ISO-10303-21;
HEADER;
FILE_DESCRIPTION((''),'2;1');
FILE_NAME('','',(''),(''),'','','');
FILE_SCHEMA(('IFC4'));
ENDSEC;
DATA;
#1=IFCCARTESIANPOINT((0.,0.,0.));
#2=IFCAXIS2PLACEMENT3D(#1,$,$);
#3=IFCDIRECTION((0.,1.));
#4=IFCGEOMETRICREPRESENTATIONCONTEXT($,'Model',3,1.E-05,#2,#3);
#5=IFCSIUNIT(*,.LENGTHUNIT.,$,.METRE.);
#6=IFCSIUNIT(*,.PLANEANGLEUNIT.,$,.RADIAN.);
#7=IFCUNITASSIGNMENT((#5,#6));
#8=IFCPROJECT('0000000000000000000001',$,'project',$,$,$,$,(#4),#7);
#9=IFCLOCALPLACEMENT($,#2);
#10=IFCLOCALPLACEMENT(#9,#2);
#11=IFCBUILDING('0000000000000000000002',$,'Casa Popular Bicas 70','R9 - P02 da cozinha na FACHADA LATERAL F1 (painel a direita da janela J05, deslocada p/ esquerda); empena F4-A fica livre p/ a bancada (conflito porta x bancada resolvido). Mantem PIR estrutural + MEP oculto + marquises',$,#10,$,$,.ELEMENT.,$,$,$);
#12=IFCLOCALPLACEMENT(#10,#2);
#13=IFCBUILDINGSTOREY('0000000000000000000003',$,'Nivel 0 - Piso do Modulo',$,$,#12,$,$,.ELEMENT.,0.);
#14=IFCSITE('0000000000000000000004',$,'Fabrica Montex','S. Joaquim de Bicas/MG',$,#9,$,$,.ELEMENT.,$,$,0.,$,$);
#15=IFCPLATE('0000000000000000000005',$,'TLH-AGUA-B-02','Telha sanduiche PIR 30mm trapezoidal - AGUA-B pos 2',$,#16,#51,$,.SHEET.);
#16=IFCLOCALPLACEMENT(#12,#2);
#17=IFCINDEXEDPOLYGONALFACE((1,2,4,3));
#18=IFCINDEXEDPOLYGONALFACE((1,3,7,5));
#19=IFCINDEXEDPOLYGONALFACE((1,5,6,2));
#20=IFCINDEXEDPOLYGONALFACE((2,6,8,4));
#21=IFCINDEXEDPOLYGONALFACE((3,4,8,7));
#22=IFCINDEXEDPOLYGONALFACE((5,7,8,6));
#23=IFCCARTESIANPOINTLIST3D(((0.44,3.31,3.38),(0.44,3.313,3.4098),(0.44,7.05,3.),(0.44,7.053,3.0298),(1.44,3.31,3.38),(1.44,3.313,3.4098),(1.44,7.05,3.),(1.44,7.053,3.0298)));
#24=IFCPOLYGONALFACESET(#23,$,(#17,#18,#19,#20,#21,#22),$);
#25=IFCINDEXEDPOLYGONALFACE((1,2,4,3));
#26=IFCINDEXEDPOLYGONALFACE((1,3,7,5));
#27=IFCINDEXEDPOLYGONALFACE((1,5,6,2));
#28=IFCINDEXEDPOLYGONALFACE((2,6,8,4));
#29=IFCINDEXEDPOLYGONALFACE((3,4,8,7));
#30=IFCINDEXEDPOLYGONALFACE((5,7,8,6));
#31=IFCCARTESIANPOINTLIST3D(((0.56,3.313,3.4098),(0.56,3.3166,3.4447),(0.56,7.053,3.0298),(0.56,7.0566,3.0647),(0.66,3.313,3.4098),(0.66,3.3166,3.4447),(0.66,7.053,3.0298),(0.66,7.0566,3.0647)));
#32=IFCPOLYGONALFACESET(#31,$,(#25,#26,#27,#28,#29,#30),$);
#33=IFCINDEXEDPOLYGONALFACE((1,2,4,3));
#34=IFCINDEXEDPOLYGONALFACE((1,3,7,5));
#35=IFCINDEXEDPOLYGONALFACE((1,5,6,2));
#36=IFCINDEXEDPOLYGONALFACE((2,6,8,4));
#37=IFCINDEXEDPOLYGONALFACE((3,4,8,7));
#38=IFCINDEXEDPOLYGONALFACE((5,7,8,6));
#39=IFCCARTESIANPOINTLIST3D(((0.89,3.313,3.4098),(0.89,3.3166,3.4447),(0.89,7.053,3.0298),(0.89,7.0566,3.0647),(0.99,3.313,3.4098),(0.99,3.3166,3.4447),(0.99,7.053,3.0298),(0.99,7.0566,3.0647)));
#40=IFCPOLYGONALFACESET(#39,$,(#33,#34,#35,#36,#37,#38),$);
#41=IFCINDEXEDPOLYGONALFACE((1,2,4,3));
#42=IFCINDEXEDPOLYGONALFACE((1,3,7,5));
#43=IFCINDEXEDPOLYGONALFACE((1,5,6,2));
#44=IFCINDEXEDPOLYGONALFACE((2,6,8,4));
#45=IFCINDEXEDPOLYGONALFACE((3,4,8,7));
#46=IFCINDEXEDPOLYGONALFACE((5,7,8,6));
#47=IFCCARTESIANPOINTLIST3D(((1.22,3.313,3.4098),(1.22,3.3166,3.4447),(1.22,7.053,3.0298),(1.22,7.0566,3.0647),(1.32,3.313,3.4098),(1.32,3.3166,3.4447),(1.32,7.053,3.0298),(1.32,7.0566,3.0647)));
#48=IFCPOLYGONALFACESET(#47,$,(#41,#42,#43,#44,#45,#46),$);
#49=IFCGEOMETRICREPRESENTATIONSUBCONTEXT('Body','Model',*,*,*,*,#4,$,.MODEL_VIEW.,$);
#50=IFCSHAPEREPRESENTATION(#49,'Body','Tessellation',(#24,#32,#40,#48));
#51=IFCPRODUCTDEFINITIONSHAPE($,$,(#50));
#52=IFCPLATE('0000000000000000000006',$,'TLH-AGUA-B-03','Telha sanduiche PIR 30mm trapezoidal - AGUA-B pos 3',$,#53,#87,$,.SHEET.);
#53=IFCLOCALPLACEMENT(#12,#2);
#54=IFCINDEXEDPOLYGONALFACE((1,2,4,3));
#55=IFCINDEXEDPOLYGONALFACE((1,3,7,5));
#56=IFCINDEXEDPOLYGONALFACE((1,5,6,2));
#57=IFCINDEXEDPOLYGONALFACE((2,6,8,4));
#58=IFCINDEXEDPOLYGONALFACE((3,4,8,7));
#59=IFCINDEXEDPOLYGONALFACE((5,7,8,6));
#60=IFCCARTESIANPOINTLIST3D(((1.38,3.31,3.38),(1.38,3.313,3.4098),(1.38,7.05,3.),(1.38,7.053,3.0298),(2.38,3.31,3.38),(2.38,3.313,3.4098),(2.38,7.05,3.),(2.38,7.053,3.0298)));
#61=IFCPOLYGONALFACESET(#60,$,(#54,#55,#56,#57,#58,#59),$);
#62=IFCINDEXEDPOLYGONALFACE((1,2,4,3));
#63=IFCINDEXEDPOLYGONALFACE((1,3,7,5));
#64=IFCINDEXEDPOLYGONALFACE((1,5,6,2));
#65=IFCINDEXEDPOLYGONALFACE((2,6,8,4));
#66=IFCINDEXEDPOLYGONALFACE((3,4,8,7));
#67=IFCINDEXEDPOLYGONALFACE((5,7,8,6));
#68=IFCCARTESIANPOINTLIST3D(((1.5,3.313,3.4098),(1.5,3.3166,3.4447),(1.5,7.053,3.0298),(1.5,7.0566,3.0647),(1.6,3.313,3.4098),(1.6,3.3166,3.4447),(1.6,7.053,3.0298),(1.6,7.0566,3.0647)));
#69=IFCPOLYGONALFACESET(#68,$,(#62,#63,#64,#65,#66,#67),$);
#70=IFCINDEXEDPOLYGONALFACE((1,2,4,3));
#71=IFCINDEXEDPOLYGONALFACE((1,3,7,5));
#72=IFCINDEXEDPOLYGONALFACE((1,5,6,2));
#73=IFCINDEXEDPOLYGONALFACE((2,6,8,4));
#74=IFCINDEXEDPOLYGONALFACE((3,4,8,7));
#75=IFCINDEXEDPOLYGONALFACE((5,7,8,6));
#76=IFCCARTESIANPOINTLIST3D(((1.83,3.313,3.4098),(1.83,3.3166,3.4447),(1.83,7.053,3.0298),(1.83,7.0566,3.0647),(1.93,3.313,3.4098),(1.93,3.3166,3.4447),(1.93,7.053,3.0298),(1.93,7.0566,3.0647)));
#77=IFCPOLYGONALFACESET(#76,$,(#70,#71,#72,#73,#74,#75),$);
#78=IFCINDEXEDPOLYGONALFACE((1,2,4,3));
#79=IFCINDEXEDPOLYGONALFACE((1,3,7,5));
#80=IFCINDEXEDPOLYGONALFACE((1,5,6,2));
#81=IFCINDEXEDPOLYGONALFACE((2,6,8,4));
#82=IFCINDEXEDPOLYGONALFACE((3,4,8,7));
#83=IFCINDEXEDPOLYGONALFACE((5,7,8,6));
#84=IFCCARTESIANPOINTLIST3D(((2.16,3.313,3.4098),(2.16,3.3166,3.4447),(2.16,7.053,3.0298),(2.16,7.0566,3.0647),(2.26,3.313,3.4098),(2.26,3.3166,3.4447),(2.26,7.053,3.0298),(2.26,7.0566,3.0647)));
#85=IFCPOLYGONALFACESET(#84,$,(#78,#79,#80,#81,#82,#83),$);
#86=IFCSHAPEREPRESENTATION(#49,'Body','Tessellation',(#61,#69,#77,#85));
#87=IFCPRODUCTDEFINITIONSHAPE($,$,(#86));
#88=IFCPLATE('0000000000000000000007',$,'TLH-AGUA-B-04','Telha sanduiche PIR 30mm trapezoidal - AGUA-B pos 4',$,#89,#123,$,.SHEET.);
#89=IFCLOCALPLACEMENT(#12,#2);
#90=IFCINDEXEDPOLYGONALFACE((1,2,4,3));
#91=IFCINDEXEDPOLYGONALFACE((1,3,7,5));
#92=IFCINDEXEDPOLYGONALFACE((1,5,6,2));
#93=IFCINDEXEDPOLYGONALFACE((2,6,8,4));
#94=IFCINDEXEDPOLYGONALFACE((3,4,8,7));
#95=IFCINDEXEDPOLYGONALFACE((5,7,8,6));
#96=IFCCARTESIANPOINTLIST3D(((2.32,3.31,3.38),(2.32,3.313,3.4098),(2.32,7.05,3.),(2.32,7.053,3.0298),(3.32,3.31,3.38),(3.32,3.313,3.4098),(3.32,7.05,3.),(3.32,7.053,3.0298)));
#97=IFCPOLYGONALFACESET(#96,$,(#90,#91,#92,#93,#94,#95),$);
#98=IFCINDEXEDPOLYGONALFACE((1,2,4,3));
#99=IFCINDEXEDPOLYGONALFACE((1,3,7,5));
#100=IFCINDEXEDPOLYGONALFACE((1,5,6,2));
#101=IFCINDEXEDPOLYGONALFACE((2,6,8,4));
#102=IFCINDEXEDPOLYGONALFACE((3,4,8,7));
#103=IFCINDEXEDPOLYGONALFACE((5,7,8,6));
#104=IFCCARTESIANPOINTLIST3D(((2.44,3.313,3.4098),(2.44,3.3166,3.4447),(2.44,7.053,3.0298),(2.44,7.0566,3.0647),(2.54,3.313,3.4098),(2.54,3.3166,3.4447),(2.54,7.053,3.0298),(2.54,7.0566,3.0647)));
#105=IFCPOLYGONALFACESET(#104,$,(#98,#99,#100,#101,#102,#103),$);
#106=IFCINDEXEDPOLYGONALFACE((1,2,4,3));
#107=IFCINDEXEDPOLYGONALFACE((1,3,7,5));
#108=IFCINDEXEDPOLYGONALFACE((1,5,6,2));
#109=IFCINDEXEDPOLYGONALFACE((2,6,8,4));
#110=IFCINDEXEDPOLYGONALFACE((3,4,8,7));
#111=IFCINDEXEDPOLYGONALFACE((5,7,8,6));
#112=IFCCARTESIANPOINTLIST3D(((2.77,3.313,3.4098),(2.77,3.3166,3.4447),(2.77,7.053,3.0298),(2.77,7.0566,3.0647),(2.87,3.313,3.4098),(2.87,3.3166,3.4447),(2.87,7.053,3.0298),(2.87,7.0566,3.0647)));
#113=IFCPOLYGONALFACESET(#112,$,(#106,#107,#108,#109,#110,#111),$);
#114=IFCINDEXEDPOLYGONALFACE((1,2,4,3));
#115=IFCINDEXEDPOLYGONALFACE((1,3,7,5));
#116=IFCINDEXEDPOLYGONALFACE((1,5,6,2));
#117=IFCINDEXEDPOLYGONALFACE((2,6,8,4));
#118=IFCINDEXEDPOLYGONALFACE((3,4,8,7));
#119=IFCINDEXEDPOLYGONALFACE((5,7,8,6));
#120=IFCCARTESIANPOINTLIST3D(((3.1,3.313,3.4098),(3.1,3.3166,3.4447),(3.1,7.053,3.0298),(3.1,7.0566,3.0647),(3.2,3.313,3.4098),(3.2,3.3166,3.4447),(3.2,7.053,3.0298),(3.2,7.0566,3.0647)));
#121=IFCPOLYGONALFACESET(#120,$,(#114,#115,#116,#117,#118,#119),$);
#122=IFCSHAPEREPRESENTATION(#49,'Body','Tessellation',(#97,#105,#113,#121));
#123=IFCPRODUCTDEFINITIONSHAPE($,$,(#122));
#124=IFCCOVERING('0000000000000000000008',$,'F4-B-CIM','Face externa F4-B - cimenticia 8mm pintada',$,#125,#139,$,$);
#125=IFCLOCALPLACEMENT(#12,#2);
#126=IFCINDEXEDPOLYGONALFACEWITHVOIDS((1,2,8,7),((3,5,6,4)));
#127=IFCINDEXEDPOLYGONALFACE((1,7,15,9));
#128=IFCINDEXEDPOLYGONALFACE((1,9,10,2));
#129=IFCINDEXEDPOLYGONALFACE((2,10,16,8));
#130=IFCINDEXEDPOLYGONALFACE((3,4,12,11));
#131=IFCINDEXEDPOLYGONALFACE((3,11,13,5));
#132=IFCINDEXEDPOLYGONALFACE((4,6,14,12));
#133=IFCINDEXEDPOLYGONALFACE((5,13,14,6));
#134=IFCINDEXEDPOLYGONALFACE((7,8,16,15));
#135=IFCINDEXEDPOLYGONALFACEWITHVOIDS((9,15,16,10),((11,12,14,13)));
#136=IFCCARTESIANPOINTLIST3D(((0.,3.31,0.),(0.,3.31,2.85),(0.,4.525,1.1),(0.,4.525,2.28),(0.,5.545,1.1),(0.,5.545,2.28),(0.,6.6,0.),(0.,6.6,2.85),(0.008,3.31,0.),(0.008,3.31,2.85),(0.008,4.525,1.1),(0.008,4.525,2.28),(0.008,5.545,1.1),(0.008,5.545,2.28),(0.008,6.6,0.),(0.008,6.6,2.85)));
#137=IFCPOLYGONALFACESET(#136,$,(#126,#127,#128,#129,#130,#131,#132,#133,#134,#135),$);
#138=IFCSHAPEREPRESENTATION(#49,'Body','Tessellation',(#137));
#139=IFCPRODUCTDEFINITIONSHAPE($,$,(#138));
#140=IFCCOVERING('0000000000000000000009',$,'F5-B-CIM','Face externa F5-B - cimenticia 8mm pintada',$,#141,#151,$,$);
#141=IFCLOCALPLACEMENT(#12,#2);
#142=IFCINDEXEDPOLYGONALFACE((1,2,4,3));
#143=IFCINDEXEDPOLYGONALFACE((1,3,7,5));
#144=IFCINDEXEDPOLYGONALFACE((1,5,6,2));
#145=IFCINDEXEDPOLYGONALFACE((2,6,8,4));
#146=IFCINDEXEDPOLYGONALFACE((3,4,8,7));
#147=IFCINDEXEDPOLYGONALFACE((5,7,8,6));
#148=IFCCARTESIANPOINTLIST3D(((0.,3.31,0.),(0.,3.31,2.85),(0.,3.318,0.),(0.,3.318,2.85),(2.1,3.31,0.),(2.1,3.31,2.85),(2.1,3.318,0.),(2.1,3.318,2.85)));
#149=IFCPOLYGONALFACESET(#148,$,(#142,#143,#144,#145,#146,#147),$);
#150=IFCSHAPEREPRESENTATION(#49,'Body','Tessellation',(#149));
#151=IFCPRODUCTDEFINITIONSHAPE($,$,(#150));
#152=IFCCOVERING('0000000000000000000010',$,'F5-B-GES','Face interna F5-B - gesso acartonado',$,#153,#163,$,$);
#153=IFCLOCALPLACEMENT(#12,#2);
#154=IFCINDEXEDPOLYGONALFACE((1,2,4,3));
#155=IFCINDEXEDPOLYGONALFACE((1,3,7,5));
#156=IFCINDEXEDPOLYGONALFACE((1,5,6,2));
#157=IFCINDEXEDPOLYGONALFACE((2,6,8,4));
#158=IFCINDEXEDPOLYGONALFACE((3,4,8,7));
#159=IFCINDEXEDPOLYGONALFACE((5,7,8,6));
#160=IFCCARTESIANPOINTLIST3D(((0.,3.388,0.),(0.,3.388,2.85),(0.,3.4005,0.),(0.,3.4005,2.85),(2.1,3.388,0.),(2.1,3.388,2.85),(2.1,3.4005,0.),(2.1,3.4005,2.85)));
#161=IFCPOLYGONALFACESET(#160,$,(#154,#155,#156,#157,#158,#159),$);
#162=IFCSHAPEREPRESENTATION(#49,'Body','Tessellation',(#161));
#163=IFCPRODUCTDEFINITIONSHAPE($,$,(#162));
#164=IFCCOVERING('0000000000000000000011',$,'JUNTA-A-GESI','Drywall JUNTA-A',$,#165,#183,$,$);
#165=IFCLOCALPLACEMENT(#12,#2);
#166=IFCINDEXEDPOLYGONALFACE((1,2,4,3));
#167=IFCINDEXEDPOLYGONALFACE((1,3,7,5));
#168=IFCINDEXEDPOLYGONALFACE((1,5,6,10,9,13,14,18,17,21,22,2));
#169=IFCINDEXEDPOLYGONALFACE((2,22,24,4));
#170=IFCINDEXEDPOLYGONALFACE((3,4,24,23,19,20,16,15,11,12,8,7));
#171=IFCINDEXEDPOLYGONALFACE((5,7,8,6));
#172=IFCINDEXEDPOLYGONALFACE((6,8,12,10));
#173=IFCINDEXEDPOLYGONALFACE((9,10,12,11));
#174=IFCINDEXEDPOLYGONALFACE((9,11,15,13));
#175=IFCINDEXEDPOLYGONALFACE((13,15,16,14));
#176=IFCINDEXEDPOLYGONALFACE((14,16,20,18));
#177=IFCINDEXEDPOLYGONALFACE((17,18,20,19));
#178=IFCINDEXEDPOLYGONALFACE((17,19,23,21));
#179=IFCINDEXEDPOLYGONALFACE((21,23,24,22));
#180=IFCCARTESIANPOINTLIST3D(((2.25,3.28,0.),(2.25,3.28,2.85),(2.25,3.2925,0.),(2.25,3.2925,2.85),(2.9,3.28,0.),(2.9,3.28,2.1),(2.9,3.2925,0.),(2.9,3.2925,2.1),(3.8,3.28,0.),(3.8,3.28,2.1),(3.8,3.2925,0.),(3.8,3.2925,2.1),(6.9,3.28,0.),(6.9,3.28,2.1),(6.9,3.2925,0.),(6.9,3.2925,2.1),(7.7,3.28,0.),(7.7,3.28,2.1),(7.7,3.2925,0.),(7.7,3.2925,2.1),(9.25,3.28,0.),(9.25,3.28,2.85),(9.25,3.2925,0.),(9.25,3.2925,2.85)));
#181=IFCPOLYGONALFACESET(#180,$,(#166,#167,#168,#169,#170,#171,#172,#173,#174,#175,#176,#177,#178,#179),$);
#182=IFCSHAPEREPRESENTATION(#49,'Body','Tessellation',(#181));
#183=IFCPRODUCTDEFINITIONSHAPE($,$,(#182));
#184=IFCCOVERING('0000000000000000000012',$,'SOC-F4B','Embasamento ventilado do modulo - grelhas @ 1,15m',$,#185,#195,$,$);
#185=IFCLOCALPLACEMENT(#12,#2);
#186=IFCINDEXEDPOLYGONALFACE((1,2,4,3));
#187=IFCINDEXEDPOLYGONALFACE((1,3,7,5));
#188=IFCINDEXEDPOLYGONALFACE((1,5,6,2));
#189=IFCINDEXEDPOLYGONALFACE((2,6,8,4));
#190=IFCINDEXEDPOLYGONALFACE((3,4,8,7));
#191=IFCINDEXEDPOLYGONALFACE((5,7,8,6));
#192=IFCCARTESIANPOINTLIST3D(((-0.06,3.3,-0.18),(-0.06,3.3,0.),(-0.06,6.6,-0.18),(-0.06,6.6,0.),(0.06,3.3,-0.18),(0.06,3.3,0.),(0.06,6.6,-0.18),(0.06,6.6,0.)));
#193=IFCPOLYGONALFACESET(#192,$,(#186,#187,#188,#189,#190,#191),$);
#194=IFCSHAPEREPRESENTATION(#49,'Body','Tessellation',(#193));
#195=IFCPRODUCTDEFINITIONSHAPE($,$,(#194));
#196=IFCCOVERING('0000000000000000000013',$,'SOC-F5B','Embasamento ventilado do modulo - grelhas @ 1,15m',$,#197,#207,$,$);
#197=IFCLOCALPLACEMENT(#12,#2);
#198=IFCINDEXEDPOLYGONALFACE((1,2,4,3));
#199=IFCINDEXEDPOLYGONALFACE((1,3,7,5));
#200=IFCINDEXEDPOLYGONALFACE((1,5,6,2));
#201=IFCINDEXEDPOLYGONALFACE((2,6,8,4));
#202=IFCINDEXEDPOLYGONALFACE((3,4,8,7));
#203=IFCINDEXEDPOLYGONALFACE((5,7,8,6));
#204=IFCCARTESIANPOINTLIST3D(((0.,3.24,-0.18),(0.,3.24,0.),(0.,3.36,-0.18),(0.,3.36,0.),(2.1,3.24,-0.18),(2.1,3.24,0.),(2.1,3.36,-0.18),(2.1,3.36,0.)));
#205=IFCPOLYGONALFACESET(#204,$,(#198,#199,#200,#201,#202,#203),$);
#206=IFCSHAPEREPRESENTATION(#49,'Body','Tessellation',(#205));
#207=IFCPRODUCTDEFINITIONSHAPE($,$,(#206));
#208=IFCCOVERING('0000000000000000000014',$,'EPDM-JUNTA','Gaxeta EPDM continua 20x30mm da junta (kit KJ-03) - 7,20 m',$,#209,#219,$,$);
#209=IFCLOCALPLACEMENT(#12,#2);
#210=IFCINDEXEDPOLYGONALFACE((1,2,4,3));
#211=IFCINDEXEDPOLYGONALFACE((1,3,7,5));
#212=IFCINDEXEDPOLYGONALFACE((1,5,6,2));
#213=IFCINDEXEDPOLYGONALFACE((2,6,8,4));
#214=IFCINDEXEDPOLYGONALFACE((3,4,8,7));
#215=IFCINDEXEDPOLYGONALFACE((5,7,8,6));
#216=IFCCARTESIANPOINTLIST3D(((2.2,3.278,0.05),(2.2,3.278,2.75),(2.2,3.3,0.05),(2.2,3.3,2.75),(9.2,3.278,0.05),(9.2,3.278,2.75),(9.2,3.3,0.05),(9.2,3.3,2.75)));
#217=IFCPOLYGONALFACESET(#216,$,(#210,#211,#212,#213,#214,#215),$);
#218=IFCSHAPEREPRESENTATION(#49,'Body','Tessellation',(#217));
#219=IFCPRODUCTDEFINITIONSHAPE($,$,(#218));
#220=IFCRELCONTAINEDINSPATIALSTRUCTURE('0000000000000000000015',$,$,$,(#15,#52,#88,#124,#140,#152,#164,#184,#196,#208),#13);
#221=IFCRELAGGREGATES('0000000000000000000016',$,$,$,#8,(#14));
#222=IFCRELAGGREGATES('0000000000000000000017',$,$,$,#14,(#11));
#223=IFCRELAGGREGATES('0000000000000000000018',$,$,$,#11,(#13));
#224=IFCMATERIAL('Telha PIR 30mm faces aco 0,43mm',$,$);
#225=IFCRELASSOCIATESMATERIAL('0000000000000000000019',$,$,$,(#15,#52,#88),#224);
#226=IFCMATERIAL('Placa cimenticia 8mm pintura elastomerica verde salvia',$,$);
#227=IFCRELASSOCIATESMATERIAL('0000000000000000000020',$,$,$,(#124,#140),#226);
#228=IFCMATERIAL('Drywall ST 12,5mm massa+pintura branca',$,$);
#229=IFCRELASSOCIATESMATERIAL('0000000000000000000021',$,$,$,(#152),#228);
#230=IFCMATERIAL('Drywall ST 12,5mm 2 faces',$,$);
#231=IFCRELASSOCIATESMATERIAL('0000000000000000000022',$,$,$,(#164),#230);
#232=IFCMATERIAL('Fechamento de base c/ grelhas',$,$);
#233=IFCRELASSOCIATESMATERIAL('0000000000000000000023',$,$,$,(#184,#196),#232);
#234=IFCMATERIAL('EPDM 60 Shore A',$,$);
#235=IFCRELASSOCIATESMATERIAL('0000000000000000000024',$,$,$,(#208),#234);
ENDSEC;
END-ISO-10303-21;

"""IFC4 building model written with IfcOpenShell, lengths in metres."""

from ifc_helpers import new_model, si_unit, direction, frame, frame_2d, origin, origin_2d, place, context, subcontext, project, spatial, rectangle, extrude, material, element, save


model = new_model("IFC4")

# Units and contexts
model_context = context("Model", 3, precision=1e-05, world=origin(), true_north=direction((0.0, 1.0)))
body_context = subcontext(model_context, "Body", "Model", "MODEL_VIEW")
ifc_project = project(units=[si_unit("LENGTHUNIT", "METRE"), si_unit("PLANEANGLEUNIT", "RADIAN")], contexts=[model_context])

# Site, building, storey
site_placement = place(None, origin())
site = spatial("IfcSite", under=ifc_project, at=site_placement, Name="Fabrica Montex", Description="S. Joaquim de Bicas/MG", CompositionType="ELEMENT", RefElevation=0.0)
building_placement = place(site_placement, origin())
building = spatial("IfcBuilding", under=site, at=building_placement, Name="Casa Popular Bicas 70", Description="R9 - P02 da cozinha na FACHADA LATERAL F1 (painel a direita da janela J05, deslocada p/ esquerda); empena F4-A fica livre p/ a bancada (conflito porta x bancada resolvido). Mantem PIR estrutural + MEP oculto + marquises", CompositionType="ELEMENT")
storey_placement = place(building_placement, origin())
storey = spatial("IfcBuildingStorey", under=building, at=storey_placement, Name="Nivel 0 - Piso do Modulo", CompositionType="ELEMENT", Elevation=0.0)

# Plates
ifc_material_1 = material(Name="Telha PIR 30mm faces aco 0,43mm")
for number, where, z_axis, x_axis, name, description in (
    (1, (0.44, 3.31, 3.38), (0.0, 0.101084, 0.994878), (1.0, 0.0, 0.0), "TLH-AGUA-B-02", "Telha sanduiche PIR 30mm trapezoidal - AGUA-B pos 2"),
    (2, (1.38, 3.31, 3.38), (0.0, 0.101084, 0.994878), (1.0, 0.0, 0.0), "TLH-AGUA-B-03", "Telha sanduiche PIR 30mm trapezoidal - AGUA-B pos 3"),
    (3, (2.32, 3.31, 3.38), (0.0, 0.101084, 0.994878), (1.0, 0.0, 0.0), "TLH-AGUA-B-04", "Telha sanduiche PIR 30mm trapezoidal - AGUA-B pos 4"),
):
    element("IfcPlate", number, at=place(storey_placement, frame(where, z_axis=z_axis, x_axis=x_axis)), inside=storey, material=ifc_material_1, Name=name, Description=description, PredefinedType="SHEET", context=body_context, shape_type="SweptSolid", body=[
        extrude(rectangle(XDim=1.0, YDim=3.7593, at=frame_2d((0.5, 1.8796))), origin(), (0.0, 0.0, 1.0), 0.03),
        extrude(rectangle(XDim=0.1, YDim=3.7593, at=frame_2d((0.17, 1.8796))), frame((0.0, 0.0, 0.03)), (0.0, 0.0, 1.0), 0.035),
        extrude(rectangle(XDim=0.1, YDim=3.7593, at=frame_2d((0.5, 1.8796))), frame((0.0, 0.0, 0.03)), (0.0, 0.0, 1.0), 0.035),
        extrude(rectangle(XDim=0.1, YDim=3.7593, at=frame_2d((0.83, 1.8796))), frame((0.0, 0.0, 0.03)), (0.0, 0.0, 1.0), 0.035),
    ])

# Covering, opening
ifc_material_2 = material(Name="Placa cimenticia 8mm pintura elastomerica verde salvia")
covering_1_placement = place(storey_placement, frame((0.004, 3.31, 0.0), x_axis=(0.0, 1.0, 0.0)))
covering_1 = element("IfcCovering", 4, at=covering_1_placement, inside=storey, material=ifc_material_2, Name="F4-B-CIM", Description="Face externa F4-B - cimenticia 8mm pintada", context=body_context, shape_type="SweptSolid", body=[
    extrude(rectangle(XDim=3.29, YDim=0.008, at=frame_2d((1.645, 0.0))), origin(), (0.0, 0.0, 1.0), 2.85),
])
opening_1_placement = place(storey_placement, frame((0.004, 4.535, 1.1), x_axis=(0.0, 1.0, 0.0)))
element("IfcOpeningElement", 5, at=opening_1_placement, cuts=covering_1, PredefinedType="OPENING", context=body_context, shape_type="SweptSolid", body=[
    extrude(rectangle(XDim=1.02, YDim=0.03, at=frame_2d((0.5, 0.0))), origin(), (0.0, 0.0, 1.0), 1.18),
])
ifc_material_3 = material(Name="Drywall ST 12,5mm massa+pintura branca")

# Coverings
covering_2_placement = place(storey_placement, frame((0.0, 3.314, 0.0), x_axis=(1.0, 0.0, 0.0)))
element("IfcCovering", 6, at=covering_2_placement, inside=storey, material=ifc_material_2, Name="F5-B-CIM", Description="Face externa F5-B - cimenticia 8mm pintada", context=body_context, shape_type="SweptSolid", body=[
    extrude(rectangle(XDim=2.1, YDim=0.008, at=frame_2d((1.05, 0.0))), origin(), (0.0, 0.0, 1.0), 2.85),
])
covering_3_placement = place(storey_placement, frame((0.0, 3.3942, 0.0), x_axis=(1.0, 0.0, 0.0)))
element("IfcCovering", 7, at=covering_3_placement, inside=storey, material=ifc_material_3, Name="F5-B-GES", Description="Face interna F5-B - gesso acartonado", context=body_context, shape_type="SweptSolid", body=[
    extrude(rectangle(XDim=2.1, YDim=0.0125, at=frame_2d((1.05, 0.0))), origin(), (0.0, 0.0, 1.0), 2.85),
])

# Covering, openings
ifc_material_4 = material(Name="Drywall ST 12,5mm 2 faces")
covering_4_placement = place(storey_placement, frame((2.25, 3.2862, 0.0), x_axis=(1.0, 0.0, 0.0)))
covering_4 = element("IfcCovering", 8, at=covering_4_placement, inside=storey, material=ifc_material_4, Name="JUNTA-A-GESI", Description="Drywall JUNTA-A", context=body_context, shape_type="SweptSolid", body=[
    extrude(rectangle(XDim=7.0, YDim=0.0125, at=frame_2d((3.5, 0.0))), origin(), (0.0, 0.0, 1.0), 2.85),
])
opening_2_placement = place(storey_placement, frame((3.35, 3.2862, 0.0)))
element("IfcOpeningElement", 9, at=opening_2_placement, cuts=covering_4, PredefinedType="OPENING", context=body_context, shape_type="SweptSolid", body=[
    extrude(rectangle(XDim=0.9, YDim=0.0425, at=origin_2d()), origin(), (0.0, 0.0, 1.0), 2.1),
])
opening_3_placement = place(storey_placement, frame((7.3, 3.2862, 0.0)))
element("IfcOpeningElement", 10, at=opening_3_placement, cuts=covering_4, PredefinedType="OPENING", context=body_context, shape_type="SweptSolid", body=[
    extrude(rectangle(XDim=0.8, YDim=0.0425, at=origin_2d()), origin(), (0.0, 0.0, 1.0), 2.1),
])

# Coverings
ifc_material_5 = material(Name="Fechamento de base c/ grelhas")
covering_5_placement = place(storey_placement, frame((0.0, 3.3, -0.18), x_axis=(0.0, 1.0, 0.0)))
element("IfcCovering", 11, at=covering_5_placement, inside=storey, material=ifc_material_5, Name="SOC-F4B", Description="Embasamento ventilado do modulo - grelhas @ 1,15m", context=body_context, shape_type="SweptSolid", body=[
    extrude(rectangle(XDim=3.3, YDim=0.12, at=frame_2d((1.65, 0.0))), origin(), (0.0, 0.0, 1.0), 0.18),
])
covering_6_placement = place(storey_placement, frame((0.0, 3.3, -0.18), x_axis=(1.0, 0.0, 0.0)))
element("IfcCovering", 12, at=covering_6_placement, inside=storey, material=ifc_material_5, Name="SOC-F5B", Description="Embasamento ventilado do modulo - grelhas @ 1,15m", context=body_context, shape_type="SweptSolid", body=[
    extrude(rectangle(XDim=2.1, YDim=0.12, at=frame_2d((1.05, 0.0))), origin(), (0.0, 0.0, 1.0), 0.18),
])
ifc_material_6 = material(Name="EPDM 60 Shore A")
covering_7_placement = place(storey_placement, frame((2.2, 3.289, 0.05), x_axis=(1.0, 0.0, 0.0)))
element("IfcCovering", 13, at=covering_7_placement, inside=storey, material=ifc_material_6, Name="EPDM-JUNTA", Description="Gaxeta EPDM continua 20x30mm da junta (kit KJ-03) - 7,20 m", context=body_context, shape_type="SweptSolid", body=[
    extrude(rectangle(XDim=7.0, YDim=0.022, at=frame_2d((3.5, 0.0))), origin(), (0.0, 0.0, 1.0), 2.7),
])

save(model, "model.ifc")
